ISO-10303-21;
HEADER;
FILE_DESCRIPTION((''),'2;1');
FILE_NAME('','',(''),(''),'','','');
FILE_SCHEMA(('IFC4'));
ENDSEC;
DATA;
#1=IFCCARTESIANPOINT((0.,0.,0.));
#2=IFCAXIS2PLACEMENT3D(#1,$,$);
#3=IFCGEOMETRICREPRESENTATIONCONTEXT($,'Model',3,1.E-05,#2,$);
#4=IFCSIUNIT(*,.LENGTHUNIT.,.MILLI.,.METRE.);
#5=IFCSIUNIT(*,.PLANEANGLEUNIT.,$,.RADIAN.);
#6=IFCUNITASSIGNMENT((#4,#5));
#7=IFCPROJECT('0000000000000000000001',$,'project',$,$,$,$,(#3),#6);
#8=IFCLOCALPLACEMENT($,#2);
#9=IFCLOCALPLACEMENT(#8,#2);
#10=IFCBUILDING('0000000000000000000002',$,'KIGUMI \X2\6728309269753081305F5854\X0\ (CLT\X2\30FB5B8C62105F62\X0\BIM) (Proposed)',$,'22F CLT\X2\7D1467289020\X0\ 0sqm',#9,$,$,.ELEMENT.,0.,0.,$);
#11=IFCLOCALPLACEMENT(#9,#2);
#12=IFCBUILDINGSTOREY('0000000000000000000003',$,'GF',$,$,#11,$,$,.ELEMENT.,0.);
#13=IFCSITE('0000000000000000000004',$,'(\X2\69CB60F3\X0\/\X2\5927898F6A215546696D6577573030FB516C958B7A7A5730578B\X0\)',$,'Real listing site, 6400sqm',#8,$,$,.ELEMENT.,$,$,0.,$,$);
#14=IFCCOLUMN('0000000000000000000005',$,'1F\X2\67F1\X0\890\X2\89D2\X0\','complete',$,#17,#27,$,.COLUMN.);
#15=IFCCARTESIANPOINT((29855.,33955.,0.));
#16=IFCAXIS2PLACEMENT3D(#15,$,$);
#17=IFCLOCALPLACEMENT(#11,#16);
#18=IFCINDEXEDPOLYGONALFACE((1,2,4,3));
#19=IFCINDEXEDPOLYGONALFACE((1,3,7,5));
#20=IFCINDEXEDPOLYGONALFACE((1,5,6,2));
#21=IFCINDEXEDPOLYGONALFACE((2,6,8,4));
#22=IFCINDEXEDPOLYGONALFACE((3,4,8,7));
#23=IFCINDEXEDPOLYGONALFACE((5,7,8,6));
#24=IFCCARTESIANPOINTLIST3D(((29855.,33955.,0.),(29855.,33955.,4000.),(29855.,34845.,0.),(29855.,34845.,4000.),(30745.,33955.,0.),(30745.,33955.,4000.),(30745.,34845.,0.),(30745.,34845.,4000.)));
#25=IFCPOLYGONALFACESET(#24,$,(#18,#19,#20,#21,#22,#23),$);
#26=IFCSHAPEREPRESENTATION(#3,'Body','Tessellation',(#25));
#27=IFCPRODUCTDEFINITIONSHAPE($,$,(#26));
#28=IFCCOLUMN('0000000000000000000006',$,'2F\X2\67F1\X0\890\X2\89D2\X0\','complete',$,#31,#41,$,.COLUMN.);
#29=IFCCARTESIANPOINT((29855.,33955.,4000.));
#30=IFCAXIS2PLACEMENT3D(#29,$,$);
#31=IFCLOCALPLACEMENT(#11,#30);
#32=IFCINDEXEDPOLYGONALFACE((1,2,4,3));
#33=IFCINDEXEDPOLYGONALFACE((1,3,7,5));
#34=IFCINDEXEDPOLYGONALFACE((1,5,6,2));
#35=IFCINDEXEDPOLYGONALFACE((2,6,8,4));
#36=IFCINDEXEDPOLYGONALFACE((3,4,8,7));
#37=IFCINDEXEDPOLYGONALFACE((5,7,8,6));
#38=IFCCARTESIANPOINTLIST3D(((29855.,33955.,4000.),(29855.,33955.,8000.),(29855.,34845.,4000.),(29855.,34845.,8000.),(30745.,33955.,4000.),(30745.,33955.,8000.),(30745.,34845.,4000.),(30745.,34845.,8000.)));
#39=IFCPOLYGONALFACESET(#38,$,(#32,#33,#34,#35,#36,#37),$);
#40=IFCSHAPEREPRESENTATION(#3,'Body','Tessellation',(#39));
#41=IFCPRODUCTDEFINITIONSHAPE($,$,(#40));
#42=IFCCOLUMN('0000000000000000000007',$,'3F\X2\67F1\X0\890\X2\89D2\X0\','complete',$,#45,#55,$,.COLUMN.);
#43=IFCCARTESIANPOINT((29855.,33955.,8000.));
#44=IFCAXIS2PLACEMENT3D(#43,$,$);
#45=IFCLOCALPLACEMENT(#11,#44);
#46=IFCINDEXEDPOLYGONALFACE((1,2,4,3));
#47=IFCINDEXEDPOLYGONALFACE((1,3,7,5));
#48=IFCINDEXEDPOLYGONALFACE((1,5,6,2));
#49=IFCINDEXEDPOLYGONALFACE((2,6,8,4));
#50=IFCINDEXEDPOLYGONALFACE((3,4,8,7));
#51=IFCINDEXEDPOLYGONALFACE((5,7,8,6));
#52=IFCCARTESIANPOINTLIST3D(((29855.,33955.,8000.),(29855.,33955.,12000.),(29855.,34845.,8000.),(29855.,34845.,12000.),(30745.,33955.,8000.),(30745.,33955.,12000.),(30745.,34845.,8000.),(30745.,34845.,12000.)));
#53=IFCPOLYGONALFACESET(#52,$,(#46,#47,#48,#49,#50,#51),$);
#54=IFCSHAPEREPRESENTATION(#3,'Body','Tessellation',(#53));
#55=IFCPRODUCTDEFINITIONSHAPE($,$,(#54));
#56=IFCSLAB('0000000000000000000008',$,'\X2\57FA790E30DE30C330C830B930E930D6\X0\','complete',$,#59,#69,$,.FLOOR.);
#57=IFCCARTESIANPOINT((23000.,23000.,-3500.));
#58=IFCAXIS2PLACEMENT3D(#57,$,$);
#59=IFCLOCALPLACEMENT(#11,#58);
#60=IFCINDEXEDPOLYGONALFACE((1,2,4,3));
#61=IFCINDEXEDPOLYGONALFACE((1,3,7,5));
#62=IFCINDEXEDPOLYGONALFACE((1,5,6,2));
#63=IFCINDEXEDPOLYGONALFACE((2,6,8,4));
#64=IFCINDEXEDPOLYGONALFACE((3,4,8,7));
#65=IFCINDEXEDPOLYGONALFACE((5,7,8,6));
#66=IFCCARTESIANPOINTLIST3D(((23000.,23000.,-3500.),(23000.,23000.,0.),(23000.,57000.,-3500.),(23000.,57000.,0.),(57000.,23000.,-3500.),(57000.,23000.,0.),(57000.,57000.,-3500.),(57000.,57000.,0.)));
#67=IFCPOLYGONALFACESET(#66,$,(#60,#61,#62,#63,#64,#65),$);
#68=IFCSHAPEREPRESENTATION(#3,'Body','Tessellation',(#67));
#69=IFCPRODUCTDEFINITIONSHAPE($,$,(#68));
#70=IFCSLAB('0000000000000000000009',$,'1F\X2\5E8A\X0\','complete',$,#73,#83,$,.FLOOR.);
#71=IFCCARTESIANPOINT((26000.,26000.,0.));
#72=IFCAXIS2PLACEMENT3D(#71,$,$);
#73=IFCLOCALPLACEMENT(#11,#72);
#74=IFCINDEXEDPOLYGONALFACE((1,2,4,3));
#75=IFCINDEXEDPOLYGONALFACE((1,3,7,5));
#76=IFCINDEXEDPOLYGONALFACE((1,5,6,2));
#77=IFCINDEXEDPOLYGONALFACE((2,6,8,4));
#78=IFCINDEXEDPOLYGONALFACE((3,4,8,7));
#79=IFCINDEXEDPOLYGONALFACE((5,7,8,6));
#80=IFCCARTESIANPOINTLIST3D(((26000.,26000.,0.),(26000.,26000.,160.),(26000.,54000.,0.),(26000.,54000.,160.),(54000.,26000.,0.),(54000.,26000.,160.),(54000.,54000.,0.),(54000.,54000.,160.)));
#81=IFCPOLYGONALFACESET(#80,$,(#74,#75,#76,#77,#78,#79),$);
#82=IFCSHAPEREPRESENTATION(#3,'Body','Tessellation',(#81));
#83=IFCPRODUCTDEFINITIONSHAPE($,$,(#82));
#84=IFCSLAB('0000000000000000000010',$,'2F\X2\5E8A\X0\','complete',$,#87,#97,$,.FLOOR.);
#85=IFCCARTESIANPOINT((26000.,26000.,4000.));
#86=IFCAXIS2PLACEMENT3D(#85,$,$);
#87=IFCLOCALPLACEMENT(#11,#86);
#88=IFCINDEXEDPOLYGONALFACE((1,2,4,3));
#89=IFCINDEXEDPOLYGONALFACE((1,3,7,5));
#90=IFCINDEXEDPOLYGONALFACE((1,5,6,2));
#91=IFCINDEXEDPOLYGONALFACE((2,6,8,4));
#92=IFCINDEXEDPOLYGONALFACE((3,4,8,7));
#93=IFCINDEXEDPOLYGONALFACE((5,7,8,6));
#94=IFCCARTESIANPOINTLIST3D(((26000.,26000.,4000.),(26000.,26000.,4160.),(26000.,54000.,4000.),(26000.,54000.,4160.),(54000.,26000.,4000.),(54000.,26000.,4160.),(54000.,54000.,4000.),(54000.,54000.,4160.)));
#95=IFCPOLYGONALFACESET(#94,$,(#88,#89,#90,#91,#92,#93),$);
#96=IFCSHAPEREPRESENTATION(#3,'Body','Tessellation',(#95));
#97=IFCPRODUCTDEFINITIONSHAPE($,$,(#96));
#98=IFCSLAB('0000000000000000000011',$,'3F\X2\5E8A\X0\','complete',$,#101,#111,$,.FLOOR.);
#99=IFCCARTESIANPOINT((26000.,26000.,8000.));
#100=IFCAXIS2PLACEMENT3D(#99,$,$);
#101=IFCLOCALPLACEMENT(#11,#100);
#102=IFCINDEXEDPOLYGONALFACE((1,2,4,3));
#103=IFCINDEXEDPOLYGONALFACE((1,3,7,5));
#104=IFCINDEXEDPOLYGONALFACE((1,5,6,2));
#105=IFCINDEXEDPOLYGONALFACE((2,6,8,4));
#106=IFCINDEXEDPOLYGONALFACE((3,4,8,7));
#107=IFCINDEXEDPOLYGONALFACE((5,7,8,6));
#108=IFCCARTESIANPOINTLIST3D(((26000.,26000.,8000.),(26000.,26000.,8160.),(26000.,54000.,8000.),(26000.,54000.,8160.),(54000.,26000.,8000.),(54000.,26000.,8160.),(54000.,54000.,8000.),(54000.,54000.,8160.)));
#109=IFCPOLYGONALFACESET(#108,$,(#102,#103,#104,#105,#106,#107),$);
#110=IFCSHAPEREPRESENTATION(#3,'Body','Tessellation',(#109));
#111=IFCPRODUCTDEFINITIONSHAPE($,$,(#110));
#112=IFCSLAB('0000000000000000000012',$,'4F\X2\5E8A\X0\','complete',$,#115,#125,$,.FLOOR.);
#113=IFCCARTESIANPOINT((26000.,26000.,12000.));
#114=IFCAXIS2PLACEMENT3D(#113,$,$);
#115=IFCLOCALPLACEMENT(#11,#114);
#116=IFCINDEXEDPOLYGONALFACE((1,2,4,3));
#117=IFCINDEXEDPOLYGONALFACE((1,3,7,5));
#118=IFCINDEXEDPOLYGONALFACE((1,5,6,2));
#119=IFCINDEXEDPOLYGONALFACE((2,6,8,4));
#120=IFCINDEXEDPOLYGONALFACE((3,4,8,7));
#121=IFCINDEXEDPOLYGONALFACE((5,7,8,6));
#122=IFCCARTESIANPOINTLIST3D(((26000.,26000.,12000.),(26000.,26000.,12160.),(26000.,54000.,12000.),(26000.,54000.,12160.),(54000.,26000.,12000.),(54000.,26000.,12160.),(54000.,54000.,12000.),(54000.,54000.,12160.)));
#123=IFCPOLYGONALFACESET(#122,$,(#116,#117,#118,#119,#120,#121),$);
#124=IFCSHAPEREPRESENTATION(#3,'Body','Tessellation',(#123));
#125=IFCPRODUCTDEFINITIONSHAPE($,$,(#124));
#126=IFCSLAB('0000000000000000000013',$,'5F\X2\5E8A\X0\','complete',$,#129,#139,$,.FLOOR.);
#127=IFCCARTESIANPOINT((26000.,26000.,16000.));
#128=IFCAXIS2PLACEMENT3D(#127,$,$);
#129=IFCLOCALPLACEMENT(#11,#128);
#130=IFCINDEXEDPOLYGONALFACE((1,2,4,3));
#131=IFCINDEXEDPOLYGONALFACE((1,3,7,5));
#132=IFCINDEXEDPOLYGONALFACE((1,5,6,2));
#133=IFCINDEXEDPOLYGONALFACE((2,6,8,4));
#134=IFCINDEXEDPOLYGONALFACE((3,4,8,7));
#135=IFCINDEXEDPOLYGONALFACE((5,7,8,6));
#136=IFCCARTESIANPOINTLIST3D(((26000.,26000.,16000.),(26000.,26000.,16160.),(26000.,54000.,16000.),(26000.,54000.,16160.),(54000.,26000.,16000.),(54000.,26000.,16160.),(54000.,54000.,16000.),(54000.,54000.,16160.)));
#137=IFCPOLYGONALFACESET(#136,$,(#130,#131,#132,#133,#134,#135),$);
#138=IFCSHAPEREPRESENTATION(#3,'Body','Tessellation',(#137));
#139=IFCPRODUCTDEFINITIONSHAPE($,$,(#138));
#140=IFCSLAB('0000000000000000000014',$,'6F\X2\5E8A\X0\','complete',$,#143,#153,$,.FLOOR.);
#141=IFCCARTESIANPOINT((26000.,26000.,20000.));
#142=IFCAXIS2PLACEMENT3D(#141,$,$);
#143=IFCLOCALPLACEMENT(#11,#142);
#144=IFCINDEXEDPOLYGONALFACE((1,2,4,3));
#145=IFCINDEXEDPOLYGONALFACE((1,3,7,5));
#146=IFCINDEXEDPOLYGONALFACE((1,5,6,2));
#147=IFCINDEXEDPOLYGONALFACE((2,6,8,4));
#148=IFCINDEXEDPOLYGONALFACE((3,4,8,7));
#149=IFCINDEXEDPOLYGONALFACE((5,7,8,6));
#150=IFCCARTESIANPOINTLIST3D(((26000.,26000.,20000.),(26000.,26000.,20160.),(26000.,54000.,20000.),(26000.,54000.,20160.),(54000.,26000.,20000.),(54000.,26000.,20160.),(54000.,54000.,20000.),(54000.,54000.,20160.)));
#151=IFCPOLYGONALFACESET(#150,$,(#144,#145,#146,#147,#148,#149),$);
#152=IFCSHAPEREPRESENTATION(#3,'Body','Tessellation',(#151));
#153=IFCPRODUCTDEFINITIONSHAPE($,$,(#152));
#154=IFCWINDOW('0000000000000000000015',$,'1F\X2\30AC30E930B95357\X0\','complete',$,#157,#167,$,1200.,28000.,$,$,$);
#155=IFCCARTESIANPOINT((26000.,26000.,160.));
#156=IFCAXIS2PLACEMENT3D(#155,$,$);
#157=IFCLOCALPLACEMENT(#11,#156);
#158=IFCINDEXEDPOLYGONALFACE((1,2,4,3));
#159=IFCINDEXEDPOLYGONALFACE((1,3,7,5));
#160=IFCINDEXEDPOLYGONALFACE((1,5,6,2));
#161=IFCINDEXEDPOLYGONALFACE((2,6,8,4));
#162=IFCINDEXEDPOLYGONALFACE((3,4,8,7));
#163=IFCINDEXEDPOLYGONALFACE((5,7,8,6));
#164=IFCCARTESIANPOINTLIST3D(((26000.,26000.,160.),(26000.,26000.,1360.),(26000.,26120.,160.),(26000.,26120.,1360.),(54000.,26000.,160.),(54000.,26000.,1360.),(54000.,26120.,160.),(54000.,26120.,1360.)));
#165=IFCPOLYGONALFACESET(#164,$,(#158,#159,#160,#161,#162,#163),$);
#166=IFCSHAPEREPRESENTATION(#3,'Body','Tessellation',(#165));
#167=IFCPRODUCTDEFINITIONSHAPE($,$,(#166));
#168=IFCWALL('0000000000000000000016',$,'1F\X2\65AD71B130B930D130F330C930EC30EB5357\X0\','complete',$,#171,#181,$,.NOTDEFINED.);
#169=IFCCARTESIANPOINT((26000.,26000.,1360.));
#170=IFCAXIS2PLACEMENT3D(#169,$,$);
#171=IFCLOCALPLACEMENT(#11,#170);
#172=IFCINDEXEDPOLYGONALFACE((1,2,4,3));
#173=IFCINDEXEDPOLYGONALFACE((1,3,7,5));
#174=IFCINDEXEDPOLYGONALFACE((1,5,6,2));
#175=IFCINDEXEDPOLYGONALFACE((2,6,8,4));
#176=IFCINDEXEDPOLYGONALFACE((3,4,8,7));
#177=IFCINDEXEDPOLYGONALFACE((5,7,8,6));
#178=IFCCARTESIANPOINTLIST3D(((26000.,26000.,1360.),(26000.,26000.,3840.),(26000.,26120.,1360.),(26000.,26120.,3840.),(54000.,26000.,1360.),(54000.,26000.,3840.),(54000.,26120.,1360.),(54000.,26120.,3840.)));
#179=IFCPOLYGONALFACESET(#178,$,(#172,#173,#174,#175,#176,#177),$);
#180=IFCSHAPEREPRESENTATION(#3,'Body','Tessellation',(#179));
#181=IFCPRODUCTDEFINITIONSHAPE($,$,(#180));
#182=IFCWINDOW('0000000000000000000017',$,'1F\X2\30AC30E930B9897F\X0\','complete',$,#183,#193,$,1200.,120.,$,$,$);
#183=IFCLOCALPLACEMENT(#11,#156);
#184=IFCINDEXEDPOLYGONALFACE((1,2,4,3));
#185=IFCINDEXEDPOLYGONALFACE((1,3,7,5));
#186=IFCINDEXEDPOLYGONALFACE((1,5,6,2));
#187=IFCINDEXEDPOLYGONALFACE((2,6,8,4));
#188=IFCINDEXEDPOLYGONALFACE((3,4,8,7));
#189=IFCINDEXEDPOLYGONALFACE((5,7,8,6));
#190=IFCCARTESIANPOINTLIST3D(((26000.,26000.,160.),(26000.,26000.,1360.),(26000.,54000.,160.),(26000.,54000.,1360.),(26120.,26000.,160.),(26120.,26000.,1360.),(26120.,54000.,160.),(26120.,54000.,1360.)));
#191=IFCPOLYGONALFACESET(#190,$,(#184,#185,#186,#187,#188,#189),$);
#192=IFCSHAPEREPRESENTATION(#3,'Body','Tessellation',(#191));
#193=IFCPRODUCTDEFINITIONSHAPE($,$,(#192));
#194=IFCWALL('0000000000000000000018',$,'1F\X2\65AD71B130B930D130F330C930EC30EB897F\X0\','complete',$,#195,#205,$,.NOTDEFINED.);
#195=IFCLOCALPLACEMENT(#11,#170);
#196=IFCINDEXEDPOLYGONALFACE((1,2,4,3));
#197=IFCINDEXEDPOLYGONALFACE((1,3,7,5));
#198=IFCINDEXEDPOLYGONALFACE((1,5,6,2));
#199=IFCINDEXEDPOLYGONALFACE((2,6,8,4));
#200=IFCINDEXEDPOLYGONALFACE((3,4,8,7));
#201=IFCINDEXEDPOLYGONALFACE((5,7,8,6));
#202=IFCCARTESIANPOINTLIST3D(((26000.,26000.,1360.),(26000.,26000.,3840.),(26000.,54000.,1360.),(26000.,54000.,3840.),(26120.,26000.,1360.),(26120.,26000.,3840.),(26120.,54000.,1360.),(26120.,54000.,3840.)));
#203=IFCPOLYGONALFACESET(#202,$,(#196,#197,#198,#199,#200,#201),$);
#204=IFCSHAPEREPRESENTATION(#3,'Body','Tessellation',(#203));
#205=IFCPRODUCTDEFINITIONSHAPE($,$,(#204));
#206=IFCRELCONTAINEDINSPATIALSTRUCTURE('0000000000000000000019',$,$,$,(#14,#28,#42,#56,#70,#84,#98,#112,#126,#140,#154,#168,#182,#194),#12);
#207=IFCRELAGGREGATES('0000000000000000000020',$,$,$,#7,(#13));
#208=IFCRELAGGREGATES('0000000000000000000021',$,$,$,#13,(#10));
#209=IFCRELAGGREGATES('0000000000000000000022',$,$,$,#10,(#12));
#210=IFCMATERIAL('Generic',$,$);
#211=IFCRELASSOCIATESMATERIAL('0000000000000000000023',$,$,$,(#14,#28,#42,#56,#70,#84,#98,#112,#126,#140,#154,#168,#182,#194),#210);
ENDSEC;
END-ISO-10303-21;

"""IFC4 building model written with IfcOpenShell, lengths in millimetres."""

from ifc_helpers import new_model, si_unit, frame, frame_2d, origin, place, context, project, spatial, rectangle, extrude, material, element, save


model = new_model("IFC4")

# Units and contexts
model_context = context("Model", 3, precision=1e-05, world=origin())
ifc_project = project(units=[si_unit("LENGTHUNIT", "METRE", prefix="MILLI"), si_unit("PLANEANGLEUNIT", "RADIAN")], contexts=[model_context])

# Site, building, storey
site_placement = place(None, origin())
site = spatial("IfcSite", under=ifc_project, at=site_placement, Name="(構想/大規模商業敷地・公開空地型)", ObjectType="Real listing site, 6400sqm", CompositionType="ELEMENT", RefElevation=0.0)
building_placement = place(site_placement, origin())
building = spatial("IfcBuilding", under=site, at=building_placement, Name="KIGUMI 木を極めた塔 (CLT・完成形BIM) (Proposed)", ObjectType="22F CLT純木造 0sqm", CompositionType="ELEMENT", ElevationOfRefHeight=0.0, ElevationOfTerrain=0.0)
storey_placement = place(building_placement, origin())
storey = spatial("IfcBuildingStorey", under=building, at=storey_placement, Name="GF", CompositionType="ELEMENT", Elevation=0.0)

# Columns
ifc_material = material(Name="Generic")
column_1_placement = place(storey_placement, frame((29855.0, 33955.0, 0.0)))
element("IfcColumn", 1, at=column_1_placement, inside=storey, material=ifc_material, Name="1F柱890角", Description="complete", PredefinedType="COLUMN", context=model_context, shape_type="SweptSolid", body=[
    extrude(rectangle(XDim=890.0, YDim=890.0, at=frame_2d((445.0, 445.0))), frame((29855.0, 33955.0, 0.0)), (0.0, 0.0, 1.0), 4000.0),
])
column_2_placement = place(storey_placement, frame((29855.0, 33955.0, 4000.0)))
element("IfcColumn", 2, at=column_2_placement, inside=storey, material=ifc_material, Name="2F柱890角", Description="complete", PredefinedType="COLUMN", context=model_context, shape_type="SweptSolid", body=[
    extrude(rectangle(XDim=890.0, YDim=890.0, at=frame_2d((445.0, 445.0))), frame((29855.0, 33955.0, 4000.0)), (0.0, 0.0, 1.0), 4000.0),
])
column_3_placement = place(storey_placement, frame((29855.0, 33955.0, 8000.0)))
element("IfcColumn", 3, at=column_3_placement, inside=storey, material=ifc_material, Name="3F柱890角", Description="complete", PredefinedType="COLUMN", context=model_context, shape_type="SweptSolid", body=[
    extrude(rectangle(XDim=890.0, YDim=890.0, at=frame_2d((445.0, 445.0))), frame((29855.0, 33955.0, 8000.0)), (0.0, 0.0, 1.0), 4000.0),
])

# Slabs
slab_1_placement = place(storey_placement, frame((23000.0, 23000.0, -3500.0)))
element("IfcSlab", 4, at=slab_1_placement, inside=storey, material=ifc_material, Name="基礎マットスラブ", Description="complete", PredefinedType="FLOOR", context=model_context, shape_type="SweptSolid", body=[
    extrude(rectangle(XDim=34000.0, YDim=34000.0, at=frame_2d((17000.0, 17000.0))), frame((23000.0, 23000.0, -3500.0)), (0.0, 0.0, 1.0), 3500.0),
])
slab_2_placement = place(storey_placement, frame((26000.0, 26000.0, 0.0)))
element("IfcSlab", 5, at=slab_2_placement, inside=storey, material=ifc_material, Name="1F床", Description="complete", PredefinedType="FLOOR", context=model_context, shape_type="SweptSolid", body=[
    extrude(rectangle(XDim=28000.0, YDim=28000.0, at=frame_2d((14000.0, 14000.0))), frame((26000.0, 26000.0, 0.0)), (0.0, 0.0, 1.0), 160.0),
])
slab_3_placement = place(storey_placement, frame((26000.0, 26000.0, 4000.0)))
element("IfcSlab", 6, at=slab_3_placement, inside=storey, material=ifc_material, Name="2F床", Description="complete", PredefinedType="FLOOR", context=model_context, shape_type="SweptSolid", body=[
    extrude(rectangle(XDim=28000.0, YDim=28000.0, at=frame_2d((14000.0, 14000.0))), frame((26000.0, 26000.0, 4000.0)), (0.0, 0.0, 1.0), 160.0),
])
slab_4_placement = place(storey_placement, frame((26000.0, 26000.0, 8000.0)))
element("IfcSlab", 7, at=slab_4_placement, inside=storey, material=ifc_material, Name="3F床", Description="complete", PredefinedType="FLOOR", context=model_context, shape_type="SweptSolid", body=[
    extrude(rectangle(XDim=28000.0, YDim=28000.0, at=frame_2d((14000.0, 14000.0))), frame((26000.0, 26000.0, 8000.0)), (0.0, 0.0, 1.0), 160.0),
])
slab_5_placement = place(storey_placement, frame((26000.0, 26000.0, 12000.0)))
element("IfcSlab", 8, at=slab_5_placement, inside=storey, material=ifc_material, Name="4F床", Description="complete", PredefinedType="FLOOR", context=model_context, shape_type="SweptSolid", body=[
    extrude(rectangle(XDim=28000.0, YDim=28000.0, at=frame_2d((14000.0, 14000.0))), frame((26000.0, 26000.0, 12000.0)), (0.0, 0.0, 1.0), 160.0),
])
slab_6_placement = place(storey_placement, frame((26000.0, 26000.0, 16000.0)))
element("IfcSlab", 9, at=slab_6_placement, inside=storey, material=ifc_material, Name="5F床", Description="complete", PredefinedType="FLOOR", context=model_context, shape_type="SweptSolid", body=[
    extrude(rectangle(XDim=28000.0, YDim=28000.0, at=frame_2d((14000.0, 14000.0))), frame((26000.0, 26000.0, 16000.0)), (0.0, 0.0, 1.0), 160.0),
])
slab_7_placement = place(storey_placement, frame((26000.0, 26000.0, 20000.0)))
element("IfcSlab", 10, at=slab_7_placement, inside=storey, material=ifc_material, Name="6F床", Description="complete", PredefinedType="FLOOR", context=model_context, shape_type="SweptSolid", body=[
    extrude(rectangle(XDim=28000.0, YDim=28000.0, at=frame_2d((14000.0, 14000.0))), frame((26000.0, 26000.0, 20000.0)), (0.0, 0.0, 1.0), 160.0),
])

# Window
window_1_placement = place(storey_placement, frame((26000.0, 26000.0, 160.0)))
element("IfcWindow", 11, at=window_1_placement, inside=storey, material=ifc_material, Name="1Fガラス南", Description="complete", OverallHeight=1200.0, OverallWidth=28000.0, context=model_context, shape_type="SweptSolid", body=[
    extrude(rectangle(XDim=28000.0, YDim=120.0, at=frame_2d((14000.0, 60.0))), frame((26000.0, 26000.0, 160.0)), (0.0, 0.0, 1.0), 1200.0),
])

# Wall
wall_1_placement = place(storey_placement, frame((26000.0, 26000.0, 1360.0)))
element("IfcWall", 12, at=wall_1_placement, inside=storey, material=ifc_material, Name="1F断熱スパンドレル南", Description="complete", PredefinedType="NOTDEFINED", context=model_context, shape_type="SweptSolid", body=[
    extrude(rectangle(XDim=28000.0, YDim=120.0, at=frame_2d((14000.0, 60.0))), frame((26000.0, 26000.0, 1360.0)), (0.0, 0.0, 1.0), 2480.0),
])

# Window
window_2_placement = place(storey_placement, frame((26000.0, 26000.0, 160.0)))
element("IfcWindow", 13, at=window_2_placement, inside=storey, material=ifc_material, Name="1Fガラス西", Description="complete", OverallHeight=1200.0, OverallWidth=120.0, context=model_context, shape_type="SweptSolid", body=[
    extrude(rectangle(XDim=120.0, YDim=28000.0, at=frame_2d((60.0, 14000.0))), frame((26000.0, 26000.0, 160.0)), (0.0, 0.0, 1.0), 1200.0),
])

# Wall
wall_2_placement = place(storey_placement, frame((26000.0, 26000.0, 1360.0)))
element("IfcWall", 14, at=wall_2_placement, inside=storey, material=ifc_material, Name="1F断熱スパンドレル西", Description="complete", PredefinedType="NOTDEFINED", context=model_context, shape_type="SweptSolid", body=[
    extrude(rectangle(XDim=120.0, YDim=28000.0, at=frame_2d((60.0, 14000.0))), frame((26000.0, 26000.0, 1360.0)), (0.0, 0.0, 1.0), 2480.0),
])

save(model, "model.ifc")
